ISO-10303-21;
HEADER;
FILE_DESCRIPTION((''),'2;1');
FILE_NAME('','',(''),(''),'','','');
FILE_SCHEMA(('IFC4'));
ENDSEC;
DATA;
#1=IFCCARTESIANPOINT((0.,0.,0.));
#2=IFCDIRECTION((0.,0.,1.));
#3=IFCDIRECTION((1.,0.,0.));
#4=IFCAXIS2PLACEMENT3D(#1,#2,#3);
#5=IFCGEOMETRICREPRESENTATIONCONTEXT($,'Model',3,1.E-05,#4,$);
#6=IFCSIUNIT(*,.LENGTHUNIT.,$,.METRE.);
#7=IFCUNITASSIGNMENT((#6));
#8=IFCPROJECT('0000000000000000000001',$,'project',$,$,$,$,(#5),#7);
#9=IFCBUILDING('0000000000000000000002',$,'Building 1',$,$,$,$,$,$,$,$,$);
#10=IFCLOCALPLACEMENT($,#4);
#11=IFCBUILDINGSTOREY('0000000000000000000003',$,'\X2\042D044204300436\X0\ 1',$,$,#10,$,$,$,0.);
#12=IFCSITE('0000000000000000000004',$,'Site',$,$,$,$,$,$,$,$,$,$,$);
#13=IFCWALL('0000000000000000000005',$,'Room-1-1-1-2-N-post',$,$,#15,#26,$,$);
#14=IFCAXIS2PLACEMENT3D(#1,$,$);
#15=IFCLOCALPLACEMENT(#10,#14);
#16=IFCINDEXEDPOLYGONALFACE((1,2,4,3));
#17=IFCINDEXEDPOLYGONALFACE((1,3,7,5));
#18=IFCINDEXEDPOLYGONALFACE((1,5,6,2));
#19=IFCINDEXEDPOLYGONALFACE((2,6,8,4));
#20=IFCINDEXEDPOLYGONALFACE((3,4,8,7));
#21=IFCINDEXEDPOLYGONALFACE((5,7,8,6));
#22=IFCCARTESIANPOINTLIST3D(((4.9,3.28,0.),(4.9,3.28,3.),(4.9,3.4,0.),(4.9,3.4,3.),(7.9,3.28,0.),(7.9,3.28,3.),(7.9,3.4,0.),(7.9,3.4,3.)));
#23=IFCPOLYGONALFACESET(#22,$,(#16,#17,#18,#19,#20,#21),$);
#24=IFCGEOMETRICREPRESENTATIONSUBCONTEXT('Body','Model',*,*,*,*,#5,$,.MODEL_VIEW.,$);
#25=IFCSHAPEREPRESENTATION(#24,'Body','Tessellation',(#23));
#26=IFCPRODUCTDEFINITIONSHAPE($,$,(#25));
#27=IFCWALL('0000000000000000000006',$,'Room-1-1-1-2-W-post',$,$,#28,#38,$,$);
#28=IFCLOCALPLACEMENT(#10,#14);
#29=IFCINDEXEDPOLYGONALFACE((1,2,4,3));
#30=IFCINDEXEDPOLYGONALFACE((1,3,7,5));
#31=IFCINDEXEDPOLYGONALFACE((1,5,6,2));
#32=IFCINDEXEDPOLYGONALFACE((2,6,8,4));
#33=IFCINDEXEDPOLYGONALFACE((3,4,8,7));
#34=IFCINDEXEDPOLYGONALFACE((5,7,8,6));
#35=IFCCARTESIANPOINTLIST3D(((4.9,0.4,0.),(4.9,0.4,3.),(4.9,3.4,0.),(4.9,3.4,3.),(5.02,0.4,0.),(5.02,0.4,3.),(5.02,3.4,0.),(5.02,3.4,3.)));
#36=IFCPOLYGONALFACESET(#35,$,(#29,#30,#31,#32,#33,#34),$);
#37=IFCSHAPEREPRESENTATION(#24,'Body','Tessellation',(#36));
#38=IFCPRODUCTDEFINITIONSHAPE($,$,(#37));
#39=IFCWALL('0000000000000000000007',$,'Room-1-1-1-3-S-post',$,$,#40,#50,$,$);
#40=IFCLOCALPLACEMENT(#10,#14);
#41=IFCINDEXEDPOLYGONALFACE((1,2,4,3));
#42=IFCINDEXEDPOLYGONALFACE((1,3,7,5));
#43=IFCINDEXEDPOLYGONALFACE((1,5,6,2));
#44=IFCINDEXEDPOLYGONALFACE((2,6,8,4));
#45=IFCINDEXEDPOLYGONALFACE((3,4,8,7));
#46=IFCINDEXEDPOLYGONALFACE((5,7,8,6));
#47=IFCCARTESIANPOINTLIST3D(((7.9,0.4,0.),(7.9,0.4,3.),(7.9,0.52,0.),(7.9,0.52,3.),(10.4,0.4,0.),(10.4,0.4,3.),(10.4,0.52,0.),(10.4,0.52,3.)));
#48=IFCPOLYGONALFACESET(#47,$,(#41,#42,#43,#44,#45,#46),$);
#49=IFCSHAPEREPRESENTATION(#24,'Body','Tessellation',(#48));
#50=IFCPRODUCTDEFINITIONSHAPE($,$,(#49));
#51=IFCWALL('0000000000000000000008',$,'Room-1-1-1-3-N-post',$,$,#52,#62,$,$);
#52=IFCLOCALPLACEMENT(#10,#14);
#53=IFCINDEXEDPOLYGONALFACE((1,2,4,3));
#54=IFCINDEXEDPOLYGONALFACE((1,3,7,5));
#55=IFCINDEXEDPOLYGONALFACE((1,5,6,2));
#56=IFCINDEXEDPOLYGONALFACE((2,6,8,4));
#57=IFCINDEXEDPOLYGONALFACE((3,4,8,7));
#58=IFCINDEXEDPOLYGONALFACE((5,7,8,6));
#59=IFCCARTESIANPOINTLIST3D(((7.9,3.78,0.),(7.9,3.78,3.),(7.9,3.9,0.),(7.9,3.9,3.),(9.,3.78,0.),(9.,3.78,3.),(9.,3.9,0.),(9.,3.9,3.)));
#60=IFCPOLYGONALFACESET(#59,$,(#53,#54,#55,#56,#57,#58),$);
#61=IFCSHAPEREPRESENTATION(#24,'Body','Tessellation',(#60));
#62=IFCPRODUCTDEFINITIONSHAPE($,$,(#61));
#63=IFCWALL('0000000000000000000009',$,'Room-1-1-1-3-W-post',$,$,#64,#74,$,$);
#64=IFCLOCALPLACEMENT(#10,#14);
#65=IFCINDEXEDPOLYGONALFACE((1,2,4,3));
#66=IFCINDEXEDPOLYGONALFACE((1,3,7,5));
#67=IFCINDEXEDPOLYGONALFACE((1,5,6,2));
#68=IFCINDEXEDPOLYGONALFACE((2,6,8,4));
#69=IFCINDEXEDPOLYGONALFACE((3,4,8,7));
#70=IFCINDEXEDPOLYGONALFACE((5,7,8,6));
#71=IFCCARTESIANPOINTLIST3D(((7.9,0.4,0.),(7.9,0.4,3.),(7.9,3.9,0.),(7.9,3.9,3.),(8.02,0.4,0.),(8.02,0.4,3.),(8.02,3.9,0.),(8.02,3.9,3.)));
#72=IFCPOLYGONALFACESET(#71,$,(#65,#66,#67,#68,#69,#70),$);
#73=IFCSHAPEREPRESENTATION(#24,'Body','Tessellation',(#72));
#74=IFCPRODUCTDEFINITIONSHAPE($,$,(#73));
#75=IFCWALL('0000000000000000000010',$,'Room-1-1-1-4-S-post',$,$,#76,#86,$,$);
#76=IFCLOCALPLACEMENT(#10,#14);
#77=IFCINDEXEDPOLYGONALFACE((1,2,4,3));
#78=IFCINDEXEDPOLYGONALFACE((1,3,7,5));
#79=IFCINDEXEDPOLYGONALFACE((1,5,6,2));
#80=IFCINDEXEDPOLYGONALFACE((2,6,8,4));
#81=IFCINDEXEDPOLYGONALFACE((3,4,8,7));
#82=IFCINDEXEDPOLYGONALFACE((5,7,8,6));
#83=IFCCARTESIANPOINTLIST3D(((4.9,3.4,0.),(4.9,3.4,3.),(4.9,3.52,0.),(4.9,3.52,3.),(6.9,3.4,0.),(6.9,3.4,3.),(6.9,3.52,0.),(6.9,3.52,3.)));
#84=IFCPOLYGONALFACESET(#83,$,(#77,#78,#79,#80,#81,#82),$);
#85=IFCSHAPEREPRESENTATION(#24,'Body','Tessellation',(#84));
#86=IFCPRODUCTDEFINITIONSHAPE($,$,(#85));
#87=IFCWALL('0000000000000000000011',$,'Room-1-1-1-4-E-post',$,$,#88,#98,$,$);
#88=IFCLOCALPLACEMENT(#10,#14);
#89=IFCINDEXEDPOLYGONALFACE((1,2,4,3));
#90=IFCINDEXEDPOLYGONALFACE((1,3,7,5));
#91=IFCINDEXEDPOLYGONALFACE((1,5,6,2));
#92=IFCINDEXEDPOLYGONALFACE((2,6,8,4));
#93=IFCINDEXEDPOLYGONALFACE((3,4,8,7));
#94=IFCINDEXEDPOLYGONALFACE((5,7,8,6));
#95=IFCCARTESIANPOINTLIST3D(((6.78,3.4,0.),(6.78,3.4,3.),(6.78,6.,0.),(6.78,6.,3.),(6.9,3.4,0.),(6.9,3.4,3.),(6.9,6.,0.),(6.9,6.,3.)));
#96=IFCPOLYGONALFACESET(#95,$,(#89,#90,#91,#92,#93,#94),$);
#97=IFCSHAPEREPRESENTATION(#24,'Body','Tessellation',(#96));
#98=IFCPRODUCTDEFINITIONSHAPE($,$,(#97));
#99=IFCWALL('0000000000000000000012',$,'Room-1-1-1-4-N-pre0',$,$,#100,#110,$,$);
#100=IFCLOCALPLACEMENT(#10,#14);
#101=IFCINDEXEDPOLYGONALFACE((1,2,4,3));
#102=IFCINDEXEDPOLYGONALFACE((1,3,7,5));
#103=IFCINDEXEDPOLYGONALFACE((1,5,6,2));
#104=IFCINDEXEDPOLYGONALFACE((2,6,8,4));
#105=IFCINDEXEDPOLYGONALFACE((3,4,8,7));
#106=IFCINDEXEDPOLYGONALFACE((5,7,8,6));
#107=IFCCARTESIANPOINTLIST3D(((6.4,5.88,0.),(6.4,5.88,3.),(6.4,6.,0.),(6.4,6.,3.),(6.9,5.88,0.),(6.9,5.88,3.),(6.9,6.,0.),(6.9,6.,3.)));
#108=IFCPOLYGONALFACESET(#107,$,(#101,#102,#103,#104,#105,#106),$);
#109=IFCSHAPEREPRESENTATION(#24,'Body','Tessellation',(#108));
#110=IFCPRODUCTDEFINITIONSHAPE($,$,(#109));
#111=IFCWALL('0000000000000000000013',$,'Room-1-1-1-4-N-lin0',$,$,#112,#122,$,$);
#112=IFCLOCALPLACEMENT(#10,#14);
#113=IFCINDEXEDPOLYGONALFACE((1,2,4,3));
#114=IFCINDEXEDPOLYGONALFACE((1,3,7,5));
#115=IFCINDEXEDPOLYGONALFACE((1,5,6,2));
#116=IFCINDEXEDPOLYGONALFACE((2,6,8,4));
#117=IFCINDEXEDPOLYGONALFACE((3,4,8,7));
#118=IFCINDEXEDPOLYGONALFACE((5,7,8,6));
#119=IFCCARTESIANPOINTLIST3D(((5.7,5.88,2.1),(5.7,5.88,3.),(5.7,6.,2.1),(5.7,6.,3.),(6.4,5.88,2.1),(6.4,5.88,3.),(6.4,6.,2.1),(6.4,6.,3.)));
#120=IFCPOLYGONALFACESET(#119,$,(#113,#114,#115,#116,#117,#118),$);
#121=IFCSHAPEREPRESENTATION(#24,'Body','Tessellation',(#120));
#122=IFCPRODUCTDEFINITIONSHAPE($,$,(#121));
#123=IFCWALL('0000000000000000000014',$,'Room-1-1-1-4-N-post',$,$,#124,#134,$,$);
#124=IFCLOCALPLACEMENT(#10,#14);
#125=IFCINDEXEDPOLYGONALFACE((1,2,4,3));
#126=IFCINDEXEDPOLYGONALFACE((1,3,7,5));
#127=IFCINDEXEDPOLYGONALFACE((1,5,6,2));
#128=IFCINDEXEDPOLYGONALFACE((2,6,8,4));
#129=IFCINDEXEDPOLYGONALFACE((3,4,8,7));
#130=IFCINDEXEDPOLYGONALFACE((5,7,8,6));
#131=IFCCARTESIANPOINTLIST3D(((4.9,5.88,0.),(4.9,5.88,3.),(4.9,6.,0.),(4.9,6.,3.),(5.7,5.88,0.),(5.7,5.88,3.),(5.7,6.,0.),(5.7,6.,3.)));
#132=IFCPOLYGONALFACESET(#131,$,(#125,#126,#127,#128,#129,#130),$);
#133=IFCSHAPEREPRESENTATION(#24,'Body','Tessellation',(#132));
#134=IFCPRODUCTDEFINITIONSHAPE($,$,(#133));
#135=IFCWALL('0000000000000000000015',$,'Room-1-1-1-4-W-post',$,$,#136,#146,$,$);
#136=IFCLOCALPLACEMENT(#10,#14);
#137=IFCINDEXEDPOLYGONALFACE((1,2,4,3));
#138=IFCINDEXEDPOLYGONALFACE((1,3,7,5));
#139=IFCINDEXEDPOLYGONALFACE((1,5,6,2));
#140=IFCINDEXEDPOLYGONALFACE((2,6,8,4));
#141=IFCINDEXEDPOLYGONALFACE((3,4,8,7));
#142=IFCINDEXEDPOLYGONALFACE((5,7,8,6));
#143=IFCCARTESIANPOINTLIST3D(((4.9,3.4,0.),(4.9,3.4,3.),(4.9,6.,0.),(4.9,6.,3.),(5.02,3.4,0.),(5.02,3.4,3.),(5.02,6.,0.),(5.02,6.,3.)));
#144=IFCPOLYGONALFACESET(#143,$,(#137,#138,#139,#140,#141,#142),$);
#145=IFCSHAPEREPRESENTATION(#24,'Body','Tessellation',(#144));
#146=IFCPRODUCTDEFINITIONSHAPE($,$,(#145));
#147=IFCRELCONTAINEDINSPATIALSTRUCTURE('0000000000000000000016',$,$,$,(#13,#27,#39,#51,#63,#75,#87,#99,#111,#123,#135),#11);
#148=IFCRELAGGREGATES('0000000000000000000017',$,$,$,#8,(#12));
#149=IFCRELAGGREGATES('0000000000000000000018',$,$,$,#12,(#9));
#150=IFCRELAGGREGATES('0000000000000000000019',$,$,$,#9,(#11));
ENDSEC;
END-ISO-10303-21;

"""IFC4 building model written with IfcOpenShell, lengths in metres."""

from ifc_helpers import new_model, si_unit, frame, origin_with_axes, place, context, subcontext, project, spatial, indexed_curve, outline, extrude, element, save


model = new_model("IFC4")

# Units and contexts
model_context = context("Model", 3, precision=1e-05, world=origin_with_axes())
body_context = subcontext(model_context, "Body", "Model", "MODEL_VIEW")
ifc_project = project(units=[si_unit("LENGTHUNIT", "METRE")], contexts=[model_context])

# Site, building, storey
site = spatial("IfcSite", under=ifc_project, Name="Site")
building = spatial("IfcBuilding", under=site, Name="Building 1")
storey_placement = place(None, origin_with_axes())
storey = spatial("IfcBuildingStorey", under=building, at=storey_placement, Name="Этаж 1", Elevation=0.0)

# Walls
for number, where, z_axis, x_axis, name in (
    (1, (7.9, 3.4, 0.0), (0.0, 0.0, 1.0), (-1.0, 0.0, 0.0), "Room-1-1-1-2-N-post"),
    (2, (4.9, 3.4, 0.0), (0.0, 0.0, 1.0), (0.0, -1.0, 0.0), "Room-1-1-1-2-W-post"),
):
    element("IfcWall", number, at=place(storey_placement, frame(where, z_axis=z_axis, x_axis=x_axis)), inside=storey, Name=name, context=body_context, shape_type="SweptSolid", body=[
        extrude(outline(indexed_curve([(0.0, 0.0), (0.0, 0.12), (3.0, 0.12), (3.0, 0.0), (0.0, 0.0)], self_intersect=False)), origin_with_axes(), (0.0, 0.0, 1.0), 3.0),
    ])
wall_1_placement = place(storey_placement, frame((7.9, 0.4, 0.0), z_axis=(0.0, 0.0, 1.0), x_axis=(1.0, 0.0, 0.0)))
element("IfcWall", 3, at=wall_1_placement, inside=storey, Name="Room-1-1-1-3-S-post", context=body_context, shape_type="SweptSolid", body=[
    extrude(outline(indexed_curve([(0.0, 0.0), (0.0, 0.12), (2.5, 0.12), (2.5, 0.0), (0.0, 0.0)], self_intersect=False)), origin_with_axes(), (0.0, 0.0, 1.0), 3.0),
])
wall_2_placement = place(storey_placement, frame((9.0, 3.9, 0.0), z_axis=(0.0, 0.0, 1.0), x_axis=(-1.0, 0.0, 0.0)))
element("IfcWall", 4, at=wall_2_placement, inside=storey, Name="Room-1-1-1-3-N-post", context=body_context, shape_type="SweptSolid", body=[
    extrude(outline(indexed_curve([(0.0, 0.0), (0.0, 0.12), (1.1, 0.12), (1.1, 0.0), (0.0, 0.0)], self_intersect=False)), origin_with_axes(), (0.0, 0.0, 1.0), 3.0),
])
wall_3_placement = place(storey_placement, frame((7.9, 3.9, 0.0), z_axis=(0.0, 0.0, 1.0), x_axis=(0.0, -1.0, 0.0)))
element("IfcWall", 5, at=wall_3_placement, inside=storey, Name="Room-1-1-1-3-W-post", context=body_context, shape_type="SweptSolid", body=[
    extrude(outline(indexed_curve([(0.0, 0.0), (0.0, 0.12), (3.5, 0.12), (3.5, 0.0), (0.0, 0.0)], self_intersect=False)), origin_with_axes(), (0.0, 0.0, 1.0), 3.0),
])
wall_4_placement = place(storey_placement, frame((4.9, 3.4, 0.0), z_axis=(0.0, 0.0, 1.0), x_axis=(1.0, 0.0, 0.0)))
element("IfcWall", 6, at=wall_4_placement, inside=storey, Name="Room-1-1-1-4-S-post", context=body_context, shape_type="SweptSolid", body=[
    extrude(outline(indexed_curve([(0.0, 0.0), (0.0, 0.12), (2.0, 0.12), (2.0, 0.0), (0.0, 0.0)], self_intersect=False)), origin_with_axes(), (0.0, 0.0, 1.0), 3.0),
])
wall_5_placement = place(storey_placement, frame((6.9, 3.4, 0.0), z_axis=(0.0, 0.0, 1.0), x_axis=(0.0, 1.0, 0.0)))
element("IfcWall", 7, at=wall_5_placement, inside=storey, Name="Room-1-1-1-4-E-post", context=body_context, shape_type="SweptSolid", body=[
    extrude(outline(indexed_curve([(0.0, 0.0), (0.0, 0.12), (2.6, 0.12), (2.6, 0.0), (0.0, 0.0)], self_intersect=False)), origin_with_axes(), (0.0, 0.0, 1.0), 3.0),
])
wall_6_placement = place(storey_placement, frame((6.9, 6.0, 0.0), z_axis=(0.0, 0.0, 1.0), x_axis=(-1.0, 0.0, 0.0)))
element("IfcWall", 8, at=wall_6_placement, inside=storey, Name="Room-1-1-1-4-N-pre0", context=body_context, shape_type="SweptSolid", body=[
    extrude(outline(indexed_curve([(0.0, 0.0), (0.0, 0.12), (0.5, 0.12), (0.5, 0.0), (0.0, 0.0)], self_intersect=False)), origin_with_axes(), (0.0, 0.0, 1.0), 3.0),
])
wall_7_placement = place(storey_placement, frame((6.4, 6.0, 2.1), z_axis=(0.0, 0.0, 1.0), x_axis=(-1.0, 0.0, 0.0)))
element("IfcWall", 9, at=wall_7_placement, inside=storey, Name="Room-1-1-1-4-N-lin0", context=body_context, shape_type="SweptSolid", body=[
    extrude(outline(indexed_curve([(0.0, 0.0), (0.0, 0.12), (0.7, 0.12), (0.7, 0.0), (0.0, 0.0)], self_intersect=False)), origin_with_axes(), (0.0, 0.0, 1.0), 0.9),
])
wall_8_placement = place(storey_placement, frame((5.7, 6.0, 0.0), z_axis=(0.0, 0.0, 1.0), x_axis=(-1.0, 0.0, 0.0)))
element("IfcWall", 10, at=wall_8_placement, inside=storey, Name="Room-1-1-1-4-N-post", context=body_context, shape_type="SweptSolid", body=[
    extrude(outline(indexed_curve([(0.0, 0.0), (0.0, 0.12), (0.8, 0.12), (0.8, 0.0), (0.0, 0.0)], self_intersect=False)), origin_with_axes(), (0.0, 0.0, 1.0), 3.0),
])
wall_9_placement = place(storey_placement, frame((4.9, 6.0, 0.0), z_axis=(0.0, 0.0, 1.0), x_axis=(0.0, -1.0, 0.0)))
element("IfcWall", 11, at=wall_9_placement, inside=storey, Name="Room-1-1-1-4-W-post", context=body_context, shape_type="SweptSolid", body=[
    extrude(outline(indexed_curve([(0.0, 0.0), (0.0, 0.12), (2.6, 0.12), (2.6, 0.0), (0.0, 0.0)], self_intersect=False)), origin_with_axes(), (0.0, 0.0, 1.0), 3.0),
])

save(model, "model.ifc")
